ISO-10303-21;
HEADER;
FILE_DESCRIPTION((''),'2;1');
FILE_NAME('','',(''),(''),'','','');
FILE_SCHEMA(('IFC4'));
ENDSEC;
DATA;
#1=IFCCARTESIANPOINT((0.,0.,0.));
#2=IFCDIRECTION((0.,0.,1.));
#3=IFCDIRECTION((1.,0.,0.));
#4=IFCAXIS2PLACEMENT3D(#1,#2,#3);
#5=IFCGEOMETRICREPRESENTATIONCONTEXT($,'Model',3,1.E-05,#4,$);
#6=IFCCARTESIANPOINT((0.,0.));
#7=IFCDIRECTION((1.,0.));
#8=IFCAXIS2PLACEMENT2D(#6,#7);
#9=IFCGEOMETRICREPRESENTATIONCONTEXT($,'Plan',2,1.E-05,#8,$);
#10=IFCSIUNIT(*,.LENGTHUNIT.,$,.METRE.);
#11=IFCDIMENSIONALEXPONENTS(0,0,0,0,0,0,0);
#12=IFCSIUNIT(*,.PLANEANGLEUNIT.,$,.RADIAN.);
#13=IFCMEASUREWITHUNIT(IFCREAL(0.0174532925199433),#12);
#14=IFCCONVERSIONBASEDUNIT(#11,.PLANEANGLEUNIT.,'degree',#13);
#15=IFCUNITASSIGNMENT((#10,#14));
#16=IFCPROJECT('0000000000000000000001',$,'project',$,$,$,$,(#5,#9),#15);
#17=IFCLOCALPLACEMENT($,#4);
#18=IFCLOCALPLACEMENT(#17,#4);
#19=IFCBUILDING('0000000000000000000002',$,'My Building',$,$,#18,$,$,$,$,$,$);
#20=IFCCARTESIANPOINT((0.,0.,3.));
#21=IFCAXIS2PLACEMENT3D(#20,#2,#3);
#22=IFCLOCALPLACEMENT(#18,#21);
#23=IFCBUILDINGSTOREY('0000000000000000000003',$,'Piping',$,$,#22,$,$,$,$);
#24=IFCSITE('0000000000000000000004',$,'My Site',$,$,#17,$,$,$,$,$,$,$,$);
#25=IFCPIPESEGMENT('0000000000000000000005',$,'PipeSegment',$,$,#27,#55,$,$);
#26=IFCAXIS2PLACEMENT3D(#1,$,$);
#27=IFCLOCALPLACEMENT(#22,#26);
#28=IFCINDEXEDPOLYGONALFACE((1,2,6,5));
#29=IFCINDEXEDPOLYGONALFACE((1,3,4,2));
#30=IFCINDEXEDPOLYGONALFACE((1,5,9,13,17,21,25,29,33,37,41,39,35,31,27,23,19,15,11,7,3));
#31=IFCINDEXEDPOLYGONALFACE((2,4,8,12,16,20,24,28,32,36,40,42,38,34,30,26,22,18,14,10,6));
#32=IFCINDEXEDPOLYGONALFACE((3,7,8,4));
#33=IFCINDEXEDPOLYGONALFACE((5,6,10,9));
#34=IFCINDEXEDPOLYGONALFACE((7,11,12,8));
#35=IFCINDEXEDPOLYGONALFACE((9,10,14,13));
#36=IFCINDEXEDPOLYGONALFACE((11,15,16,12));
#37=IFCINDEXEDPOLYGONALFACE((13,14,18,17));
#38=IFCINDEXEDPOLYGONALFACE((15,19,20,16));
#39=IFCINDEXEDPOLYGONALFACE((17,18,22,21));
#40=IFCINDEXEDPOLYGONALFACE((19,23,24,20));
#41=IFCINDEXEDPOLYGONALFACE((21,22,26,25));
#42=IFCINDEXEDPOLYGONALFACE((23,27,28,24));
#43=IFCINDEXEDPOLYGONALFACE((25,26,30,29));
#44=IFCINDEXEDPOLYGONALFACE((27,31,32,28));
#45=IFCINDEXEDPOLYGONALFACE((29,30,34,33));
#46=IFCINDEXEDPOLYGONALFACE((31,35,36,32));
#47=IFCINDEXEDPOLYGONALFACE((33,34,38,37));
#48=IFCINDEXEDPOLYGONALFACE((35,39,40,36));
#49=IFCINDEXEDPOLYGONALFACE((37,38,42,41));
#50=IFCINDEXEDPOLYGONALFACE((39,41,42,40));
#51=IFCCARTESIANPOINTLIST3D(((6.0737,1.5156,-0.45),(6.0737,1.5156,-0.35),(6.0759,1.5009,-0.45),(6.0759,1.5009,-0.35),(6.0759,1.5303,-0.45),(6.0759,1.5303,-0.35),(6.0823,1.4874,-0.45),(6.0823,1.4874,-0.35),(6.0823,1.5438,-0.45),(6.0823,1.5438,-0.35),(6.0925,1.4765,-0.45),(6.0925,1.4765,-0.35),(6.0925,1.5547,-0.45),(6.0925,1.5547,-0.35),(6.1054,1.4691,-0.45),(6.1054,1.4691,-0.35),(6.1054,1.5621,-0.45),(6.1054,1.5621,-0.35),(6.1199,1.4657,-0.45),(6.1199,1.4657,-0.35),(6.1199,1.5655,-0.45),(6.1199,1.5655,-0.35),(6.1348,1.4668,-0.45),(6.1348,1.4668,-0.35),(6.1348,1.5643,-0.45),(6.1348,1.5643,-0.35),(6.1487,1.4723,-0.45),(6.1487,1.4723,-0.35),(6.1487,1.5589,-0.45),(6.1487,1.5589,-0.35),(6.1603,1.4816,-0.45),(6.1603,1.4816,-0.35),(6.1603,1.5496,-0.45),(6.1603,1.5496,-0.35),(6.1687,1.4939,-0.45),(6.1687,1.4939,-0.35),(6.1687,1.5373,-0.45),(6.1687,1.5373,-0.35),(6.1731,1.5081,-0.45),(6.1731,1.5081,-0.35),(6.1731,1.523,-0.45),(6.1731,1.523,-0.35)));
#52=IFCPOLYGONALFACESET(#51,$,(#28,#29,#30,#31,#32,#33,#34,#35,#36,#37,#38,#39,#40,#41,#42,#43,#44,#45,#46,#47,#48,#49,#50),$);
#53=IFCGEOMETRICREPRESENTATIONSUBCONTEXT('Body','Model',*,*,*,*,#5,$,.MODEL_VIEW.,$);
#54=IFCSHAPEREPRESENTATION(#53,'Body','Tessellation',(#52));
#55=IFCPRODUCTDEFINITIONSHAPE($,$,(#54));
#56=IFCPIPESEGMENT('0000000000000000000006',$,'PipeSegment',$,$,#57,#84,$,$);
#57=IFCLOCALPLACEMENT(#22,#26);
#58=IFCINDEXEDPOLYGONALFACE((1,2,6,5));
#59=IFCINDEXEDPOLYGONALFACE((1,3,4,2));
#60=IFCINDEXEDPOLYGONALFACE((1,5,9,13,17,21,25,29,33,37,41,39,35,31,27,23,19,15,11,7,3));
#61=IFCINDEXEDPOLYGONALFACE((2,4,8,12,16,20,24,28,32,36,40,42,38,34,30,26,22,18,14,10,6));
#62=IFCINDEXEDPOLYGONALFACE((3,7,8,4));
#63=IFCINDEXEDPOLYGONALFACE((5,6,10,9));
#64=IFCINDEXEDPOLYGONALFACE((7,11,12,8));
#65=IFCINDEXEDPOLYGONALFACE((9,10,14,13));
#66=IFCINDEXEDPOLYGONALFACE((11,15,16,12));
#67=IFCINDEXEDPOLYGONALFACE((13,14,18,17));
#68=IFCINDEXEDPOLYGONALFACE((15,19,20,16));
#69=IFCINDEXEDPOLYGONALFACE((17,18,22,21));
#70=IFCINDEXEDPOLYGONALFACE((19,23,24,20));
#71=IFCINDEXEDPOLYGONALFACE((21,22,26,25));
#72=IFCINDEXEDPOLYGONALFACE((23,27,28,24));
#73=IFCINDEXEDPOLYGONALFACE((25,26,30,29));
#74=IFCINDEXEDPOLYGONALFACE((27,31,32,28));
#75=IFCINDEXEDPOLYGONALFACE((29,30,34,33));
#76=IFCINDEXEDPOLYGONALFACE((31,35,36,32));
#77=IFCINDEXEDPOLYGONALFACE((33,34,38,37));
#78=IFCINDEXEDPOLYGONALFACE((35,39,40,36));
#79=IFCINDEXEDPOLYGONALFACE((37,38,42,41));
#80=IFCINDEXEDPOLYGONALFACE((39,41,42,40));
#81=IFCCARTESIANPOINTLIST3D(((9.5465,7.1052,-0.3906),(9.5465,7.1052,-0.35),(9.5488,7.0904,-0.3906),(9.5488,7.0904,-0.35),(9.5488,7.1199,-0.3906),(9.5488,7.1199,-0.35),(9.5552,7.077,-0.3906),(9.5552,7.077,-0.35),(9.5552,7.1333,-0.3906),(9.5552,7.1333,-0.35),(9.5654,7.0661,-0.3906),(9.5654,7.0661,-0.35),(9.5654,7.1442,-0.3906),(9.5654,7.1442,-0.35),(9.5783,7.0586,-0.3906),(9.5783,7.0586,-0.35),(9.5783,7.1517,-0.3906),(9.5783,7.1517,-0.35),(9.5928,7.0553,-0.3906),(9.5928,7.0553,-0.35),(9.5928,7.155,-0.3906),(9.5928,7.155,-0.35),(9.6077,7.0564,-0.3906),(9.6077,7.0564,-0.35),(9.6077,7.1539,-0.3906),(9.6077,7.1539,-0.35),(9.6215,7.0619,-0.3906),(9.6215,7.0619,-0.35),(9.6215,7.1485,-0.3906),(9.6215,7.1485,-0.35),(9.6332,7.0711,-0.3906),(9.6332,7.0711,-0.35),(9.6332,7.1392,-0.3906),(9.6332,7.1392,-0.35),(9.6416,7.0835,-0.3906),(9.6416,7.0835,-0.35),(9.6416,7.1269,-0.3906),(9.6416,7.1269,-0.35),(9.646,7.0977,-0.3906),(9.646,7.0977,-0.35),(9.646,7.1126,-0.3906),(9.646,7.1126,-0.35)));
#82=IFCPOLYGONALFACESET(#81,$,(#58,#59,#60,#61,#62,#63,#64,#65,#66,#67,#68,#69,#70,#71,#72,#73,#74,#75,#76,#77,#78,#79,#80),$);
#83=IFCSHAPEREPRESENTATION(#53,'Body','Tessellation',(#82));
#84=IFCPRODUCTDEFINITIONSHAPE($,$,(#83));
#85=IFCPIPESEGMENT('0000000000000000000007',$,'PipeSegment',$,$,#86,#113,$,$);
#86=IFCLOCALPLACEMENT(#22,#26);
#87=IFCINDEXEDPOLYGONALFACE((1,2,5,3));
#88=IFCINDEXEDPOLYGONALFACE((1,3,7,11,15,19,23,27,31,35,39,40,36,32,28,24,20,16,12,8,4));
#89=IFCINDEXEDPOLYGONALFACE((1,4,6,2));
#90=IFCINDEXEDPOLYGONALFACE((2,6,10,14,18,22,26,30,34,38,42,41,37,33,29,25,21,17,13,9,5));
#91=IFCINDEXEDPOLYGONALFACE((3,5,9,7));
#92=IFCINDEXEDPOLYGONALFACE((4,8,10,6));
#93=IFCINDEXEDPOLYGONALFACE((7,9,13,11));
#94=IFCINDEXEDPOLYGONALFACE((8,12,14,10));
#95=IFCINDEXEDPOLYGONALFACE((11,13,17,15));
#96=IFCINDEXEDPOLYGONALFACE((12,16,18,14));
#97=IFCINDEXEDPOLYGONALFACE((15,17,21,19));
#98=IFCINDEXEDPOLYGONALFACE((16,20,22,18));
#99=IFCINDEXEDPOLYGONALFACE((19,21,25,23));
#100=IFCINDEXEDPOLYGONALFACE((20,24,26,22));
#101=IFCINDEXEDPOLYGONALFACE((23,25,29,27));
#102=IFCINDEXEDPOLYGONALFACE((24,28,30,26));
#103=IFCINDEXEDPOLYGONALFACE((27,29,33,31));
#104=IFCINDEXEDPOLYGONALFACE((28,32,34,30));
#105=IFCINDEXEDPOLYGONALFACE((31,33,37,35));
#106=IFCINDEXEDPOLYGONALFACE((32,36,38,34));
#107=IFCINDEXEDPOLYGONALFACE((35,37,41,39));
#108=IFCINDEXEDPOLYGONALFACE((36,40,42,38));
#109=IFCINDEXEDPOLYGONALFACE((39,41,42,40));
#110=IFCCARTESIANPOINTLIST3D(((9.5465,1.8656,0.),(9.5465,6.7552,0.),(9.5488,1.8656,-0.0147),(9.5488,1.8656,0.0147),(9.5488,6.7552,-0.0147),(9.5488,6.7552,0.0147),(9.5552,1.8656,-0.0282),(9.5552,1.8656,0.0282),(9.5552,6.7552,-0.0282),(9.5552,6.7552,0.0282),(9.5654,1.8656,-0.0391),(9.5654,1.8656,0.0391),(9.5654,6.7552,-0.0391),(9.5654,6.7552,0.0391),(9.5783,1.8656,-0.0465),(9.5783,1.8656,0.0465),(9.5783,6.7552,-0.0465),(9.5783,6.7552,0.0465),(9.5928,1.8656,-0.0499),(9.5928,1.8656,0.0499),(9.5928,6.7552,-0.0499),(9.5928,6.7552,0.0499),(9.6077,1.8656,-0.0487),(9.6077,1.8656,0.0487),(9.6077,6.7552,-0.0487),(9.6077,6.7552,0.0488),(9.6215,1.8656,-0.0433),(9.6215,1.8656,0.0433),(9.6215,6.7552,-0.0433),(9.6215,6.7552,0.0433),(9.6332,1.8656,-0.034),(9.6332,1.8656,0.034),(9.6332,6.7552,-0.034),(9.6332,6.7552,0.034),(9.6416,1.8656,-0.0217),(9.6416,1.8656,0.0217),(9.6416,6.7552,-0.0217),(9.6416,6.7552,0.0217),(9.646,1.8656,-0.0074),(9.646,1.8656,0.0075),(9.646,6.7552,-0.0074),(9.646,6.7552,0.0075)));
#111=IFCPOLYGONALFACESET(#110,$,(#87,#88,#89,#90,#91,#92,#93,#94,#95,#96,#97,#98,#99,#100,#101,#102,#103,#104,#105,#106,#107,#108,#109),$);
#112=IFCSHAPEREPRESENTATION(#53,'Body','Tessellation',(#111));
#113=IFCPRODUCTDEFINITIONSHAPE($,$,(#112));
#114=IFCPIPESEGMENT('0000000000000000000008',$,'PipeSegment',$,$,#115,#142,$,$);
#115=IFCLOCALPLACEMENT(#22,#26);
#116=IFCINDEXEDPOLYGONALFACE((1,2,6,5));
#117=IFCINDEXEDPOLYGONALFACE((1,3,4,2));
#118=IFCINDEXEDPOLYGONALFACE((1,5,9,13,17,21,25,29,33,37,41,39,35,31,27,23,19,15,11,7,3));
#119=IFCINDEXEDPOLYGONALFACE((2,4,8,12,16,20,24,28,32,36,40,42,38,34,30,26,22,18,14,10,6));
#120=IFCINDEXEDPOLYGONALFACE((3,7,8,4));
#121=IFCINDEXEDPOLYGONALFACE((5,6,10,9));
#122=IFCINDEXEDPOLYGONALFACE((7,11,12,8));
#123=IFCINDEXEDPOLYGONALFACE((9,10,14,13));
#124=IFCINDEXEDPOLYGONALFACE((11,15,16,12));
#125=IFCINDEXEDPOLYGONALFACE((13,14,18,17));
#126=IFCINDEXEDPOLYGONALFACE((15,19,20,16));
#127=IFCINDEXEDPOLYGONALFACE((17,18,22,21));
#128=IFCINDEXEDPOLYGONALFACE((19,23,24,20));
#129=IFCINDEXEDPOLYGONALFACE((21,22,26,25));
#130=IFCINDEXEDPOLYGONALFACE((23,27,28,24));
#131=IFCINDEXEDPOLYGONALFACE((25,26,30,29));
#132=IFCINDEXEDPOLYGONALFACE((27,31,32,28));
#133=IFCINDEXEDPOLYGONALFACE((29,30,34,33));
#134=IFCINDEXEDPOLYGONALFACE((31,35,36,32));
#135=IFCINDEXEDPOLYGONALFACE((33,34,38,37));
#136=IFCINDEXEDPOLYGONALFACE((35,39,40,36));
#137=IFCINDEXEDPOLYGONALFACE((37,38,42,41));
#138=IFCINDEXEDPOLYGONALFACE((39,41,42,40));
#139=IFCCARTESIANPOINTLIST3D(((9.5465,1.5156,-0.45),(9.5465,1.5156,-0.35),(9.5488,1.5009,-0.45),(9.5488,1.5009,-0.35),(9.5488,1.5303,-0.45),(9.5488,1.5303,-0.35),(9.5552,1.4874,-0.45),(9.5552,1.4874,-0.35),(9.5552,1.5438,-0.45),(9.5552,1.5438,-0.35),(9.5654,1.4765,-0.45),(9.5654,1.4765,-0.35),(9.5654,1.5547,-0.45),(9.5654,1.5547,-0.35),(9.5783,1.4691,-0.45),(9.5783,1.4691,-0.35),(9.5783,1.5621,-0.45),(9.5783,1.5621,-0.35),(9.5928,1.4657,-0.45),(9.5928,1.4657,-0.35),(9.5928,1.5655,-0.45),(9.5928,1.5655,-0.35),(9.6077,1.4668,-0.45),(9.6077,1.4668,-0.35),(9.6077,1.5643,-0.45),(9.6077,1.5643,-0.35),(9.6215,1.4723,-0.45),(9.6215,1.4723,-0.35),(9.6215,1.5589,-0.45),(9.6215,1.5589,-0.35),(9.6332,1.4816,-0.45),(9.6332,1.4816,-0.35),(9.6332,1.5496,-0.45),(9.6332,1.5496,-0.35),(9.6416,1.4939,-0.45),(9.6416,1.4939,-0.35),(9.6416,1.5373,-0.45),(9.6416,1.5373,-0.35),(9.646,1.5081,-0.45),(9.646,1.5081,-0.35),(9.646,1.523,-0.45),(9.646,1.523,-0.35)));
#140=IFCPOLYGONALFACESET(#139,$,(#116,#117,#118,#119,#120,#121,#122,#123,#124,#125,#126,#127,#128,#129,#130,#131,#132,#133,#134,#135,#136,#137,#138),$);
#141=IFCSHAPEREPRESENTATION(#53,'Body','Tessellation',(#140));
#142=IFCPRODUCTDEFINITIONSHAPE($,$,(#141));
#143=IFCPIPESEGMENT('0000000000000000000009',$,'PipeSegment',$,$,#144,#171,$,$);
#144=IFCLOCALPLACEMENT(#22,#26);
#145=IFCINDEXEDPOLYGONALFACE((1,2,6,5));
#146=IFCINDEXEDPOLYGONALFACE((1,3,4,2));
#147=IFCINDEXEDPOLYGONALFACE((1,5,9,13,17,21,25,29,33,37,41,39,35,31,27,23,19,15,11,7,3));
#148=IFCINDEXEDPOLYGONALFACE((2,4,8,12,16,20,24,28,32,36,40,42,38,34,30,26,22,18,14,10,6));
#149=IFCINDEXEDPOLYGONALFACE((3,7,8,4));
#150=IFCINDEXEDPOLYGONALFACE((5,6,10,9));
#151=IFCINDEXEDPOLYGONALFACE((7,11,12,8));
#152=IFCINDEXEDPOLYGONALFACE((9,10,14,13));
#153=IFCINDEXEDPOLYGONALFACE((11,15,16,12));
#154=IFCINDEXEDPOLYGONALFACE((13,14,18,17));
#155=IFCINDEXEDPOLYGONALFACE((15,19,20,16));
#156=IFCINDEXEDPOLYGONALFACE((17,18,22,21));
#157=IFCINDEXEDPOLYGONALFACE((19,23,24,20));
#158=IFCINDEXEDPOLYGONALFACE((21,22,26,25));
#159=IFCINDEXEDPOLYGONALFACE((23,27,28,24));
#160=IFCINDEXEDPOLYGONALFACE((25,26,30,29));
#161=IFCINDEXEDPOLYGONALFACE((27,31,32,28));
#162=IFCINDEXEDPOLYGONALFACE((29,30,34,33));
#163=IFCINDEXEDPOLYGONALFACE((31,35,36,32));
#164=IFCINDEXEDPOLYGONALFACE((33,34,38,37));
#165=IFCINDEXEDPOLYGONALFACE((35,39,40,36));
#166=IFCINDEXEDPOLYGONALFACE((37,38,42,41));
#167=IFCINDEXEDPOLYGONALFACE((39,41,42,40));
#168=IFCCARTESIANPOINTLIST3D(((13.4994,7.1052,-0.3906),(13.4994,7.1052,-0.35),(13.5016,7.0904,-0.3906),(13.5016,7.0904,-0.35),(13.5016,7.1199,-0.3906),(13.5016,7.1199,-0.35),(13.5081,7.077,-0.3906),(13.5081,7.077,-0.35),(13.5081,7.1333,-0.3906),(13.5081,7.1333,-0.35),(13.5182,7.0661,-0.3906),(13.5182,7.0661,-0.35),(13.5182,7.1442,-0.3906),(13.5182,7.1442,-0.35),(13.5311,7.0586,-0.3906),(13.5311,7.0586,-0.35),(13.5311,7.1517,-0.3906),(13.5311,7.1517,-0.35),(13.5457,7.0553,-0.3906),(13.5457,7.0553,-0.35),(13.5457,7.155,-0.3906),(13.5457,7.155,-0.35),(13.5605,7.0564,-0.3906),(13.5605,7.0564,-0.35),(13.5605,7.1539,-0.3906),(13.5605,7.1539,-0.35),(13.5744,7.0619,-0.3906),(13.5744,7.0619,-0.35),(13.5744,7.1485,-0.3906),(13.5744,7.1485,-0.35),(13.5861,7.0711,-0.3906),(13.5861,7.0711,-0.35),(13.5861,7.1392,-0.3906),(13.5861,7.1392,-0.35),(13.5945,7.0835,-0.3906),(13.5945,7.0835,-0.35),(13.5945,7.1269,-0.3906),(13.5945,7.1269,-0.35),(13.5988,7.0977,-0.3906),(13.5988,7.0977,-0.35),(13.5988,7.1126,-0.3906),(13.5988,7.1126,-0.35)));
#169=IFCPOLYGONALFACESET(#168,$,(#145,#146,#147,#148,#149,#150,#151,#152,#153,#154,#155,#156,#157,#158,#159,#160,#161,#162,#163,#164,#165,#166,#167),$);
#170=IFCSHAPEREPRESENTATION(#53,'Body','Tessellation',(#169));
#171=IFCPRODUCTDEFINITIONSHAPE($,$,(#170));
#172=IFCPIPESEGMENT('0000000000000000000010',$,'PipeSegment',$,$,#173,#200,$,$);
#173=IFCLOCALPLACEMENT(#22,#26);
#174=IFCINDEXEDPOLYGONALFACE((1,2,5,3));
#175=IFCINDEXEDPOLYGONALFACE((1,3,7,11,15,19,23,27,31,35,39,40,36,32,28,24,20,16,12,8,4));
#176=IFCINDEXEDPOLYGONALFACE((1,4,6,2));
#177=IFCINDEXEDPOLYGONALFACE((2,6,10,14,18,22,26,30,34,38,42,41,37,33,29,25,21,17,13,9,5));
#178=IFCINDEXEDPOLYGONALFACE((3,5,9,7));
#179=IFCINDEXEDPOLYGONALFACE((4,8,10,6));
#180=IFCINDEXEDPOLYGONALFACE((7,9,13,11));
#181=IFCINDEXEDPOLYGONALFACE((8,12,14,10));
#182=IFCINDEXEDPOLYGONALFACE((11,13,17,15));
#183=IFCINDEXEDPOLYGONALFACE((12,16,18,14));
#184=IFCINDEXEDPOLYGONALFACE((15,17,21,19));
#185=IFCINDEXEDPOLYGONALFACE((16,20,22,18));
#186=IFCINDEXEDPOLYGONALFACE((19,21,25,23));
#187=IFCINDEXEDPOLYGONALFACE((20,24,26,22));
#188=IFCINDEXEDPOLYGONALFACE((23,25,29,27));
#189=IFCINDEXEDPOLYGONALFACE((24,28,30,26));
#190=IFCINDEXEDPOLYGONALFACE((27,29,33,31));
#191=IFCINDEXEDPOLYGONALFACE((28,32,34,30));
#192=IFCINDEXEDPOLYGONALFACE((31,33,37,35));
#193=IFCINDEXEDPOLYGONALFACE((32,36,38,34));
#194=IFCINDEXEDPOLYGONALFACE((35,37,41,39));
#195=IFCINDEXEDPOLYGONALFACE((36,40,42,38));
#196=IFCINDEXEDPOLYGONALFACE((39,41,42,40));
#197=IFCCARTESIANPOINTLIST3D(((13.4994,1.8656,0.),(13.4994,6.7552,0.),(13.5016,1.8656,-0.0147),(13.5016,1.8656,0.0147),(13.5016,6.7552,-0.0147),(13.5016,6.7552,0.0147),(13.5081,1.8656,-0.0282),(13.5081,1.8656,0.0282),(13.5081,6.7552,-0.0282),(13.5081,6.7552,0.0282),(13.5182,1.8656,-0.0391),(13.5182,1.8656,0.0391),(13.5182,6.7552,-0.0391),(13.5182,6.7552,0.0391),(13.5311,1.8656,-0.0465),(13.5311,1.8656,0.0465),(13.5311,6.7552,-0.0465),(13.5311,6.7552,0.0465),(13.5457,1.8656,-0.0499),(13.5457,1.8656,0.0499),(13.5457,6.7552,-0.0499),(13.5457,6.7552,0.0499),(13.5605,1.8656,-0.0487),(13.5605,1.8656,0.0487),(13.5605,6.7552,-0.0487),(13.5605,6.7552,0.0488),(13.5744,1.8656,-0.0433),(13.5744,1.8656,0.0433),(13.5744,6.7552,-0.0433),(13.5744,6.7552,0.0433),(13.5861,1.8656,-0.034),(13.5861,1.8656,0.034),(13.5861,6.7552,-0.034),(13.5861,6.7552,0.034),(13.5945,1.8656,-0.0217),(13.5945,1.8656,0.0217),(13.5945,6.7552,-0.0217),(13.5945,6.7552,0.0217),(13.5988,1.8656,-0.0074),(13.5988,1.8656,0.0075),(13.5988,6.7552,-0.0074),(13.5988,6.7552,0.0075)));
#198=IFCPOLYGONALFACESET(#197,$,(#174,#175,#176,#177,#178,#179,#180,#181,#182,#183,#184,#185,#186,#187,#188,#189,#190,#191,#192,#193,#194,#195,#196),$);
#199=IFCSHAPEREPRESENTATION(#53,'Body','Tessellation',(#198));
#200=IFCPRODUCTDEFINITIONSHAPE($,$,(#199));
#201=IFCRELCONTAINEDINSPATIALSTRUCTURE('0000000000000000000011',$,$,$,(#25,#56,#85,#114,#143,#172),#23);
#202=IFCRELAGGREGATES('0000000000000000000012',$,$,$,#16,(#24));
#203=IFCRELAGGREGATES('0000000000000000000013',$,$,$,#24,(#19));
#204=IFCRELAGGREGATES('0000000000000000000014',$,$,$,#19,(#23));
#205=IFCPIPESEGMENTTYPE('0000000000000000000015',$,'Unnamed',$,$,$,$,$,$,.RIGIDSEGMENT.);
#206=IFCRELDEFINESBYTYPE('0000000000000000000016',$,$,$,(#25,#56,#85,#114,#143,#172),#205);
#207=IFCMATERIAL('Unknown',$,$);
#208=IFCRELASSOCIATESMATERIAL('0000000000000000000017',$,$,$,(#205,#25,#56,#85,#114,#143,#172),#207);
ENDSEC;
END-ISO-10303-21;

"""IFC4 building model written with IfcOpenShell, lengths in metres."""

from ifc_helpers import new_model, entity, si_unit, converted_unit, frame, origin_with_axes, origin_2d_with_axis, place, context, subcontext, project, spatial, circle, extrude, material, material_profile, profile_set, profile_usage, type_object, element, save


model = new_model("IFC4")

# Units and contexts
model_context = context("Model", 3, precision=1e-05, world=origin_with_axes())
plan_context = context("Plan", 2, precision=1e-05, world=origin_2d_with_axis())
body_context = subcontext(model_context, "Body", "Model", "MODEL_VIEW")
ifc_project = project(units=[si_unit("LENGTHUNIT", "METRE"), converted_unit("PLANEANGLEUNIT", "degree", entity("IfcReal", 0.0174532925199433), si_unit("PLANEANGLEUNIT", "RADIAN"), dimensions=[0, 0, 0, 0, 0, 0, 0])], contexts=[model_context, plan_context])

# Site, building, storey
site_placement = place(None, origin_with_axes())
site = spatial("IfcSite", under=ifc_project, at=site_placement, Name="My Site")
building_placement = place(site_placement, origin_with_axes())
building = spatial("IfcBuilding", under=site, at=building_placement, Name="My Building")
storey_placement = place(building_placement, frame((0.0, 0.0, 3.0), z_axis=(0.0, 0.0, 1.0), x_axis=(1.0, 0.0, 0.0)))
storey = spatial("IfcBuildingStorey", under=building, at=storey_placement, Name="Piping")

# Pipe segments
ifc_material = material(Name="Unknown")
ifc_material_profile = material_profile(ifc_material, circle(Radius=0.05))
ifc_profile_set = profile_set([ifc_material_profile])
pipe_segment_type = type_object("IfcPipeSegmentType", Name="Unnamed", PredefinedType="RIGIDSEGMENT", material=ifc_profile_set)
ifc_profile_usage_1 = profile_usage(ifc_profile_set, cardinal=5)
pipe_segment_1_placement = place(storey_placement, frame((6.1237, 1.5156, -0.35), z_axis=(0.0, 0.0, -1.0), x_axis=(-1.0, 0.0, 0.0)))
element("IfcPipeSegment", 1, at=pipe_segment_1_placement, inside=storey, type_object=pipe_segment_type, material=ifc_profile_usage_1, Name="PipeSegment", context=body_context, shape_type="SweptSolid", body=[
    extrude(circle(Radius=0.05), origin_with_axes(), (0.0, 0.0, 1.0), 0.1),
])
ifc_profile_usage_2 = profile_usage(ifc_profile_set, cardinal=5)
pipe_segment_2_placement = place(storey_placement, frame((9.5965, 7.1052, -0.35), z_axis=(0.0, 0.0, -1.0), x_axis=(-1.0, 0.0, 0.0)))
element("IfcPipeSegment", 2, at=pipe_segment_2_placement, inside=storey, type_object=pipe_segment_type, material=ifc_profile_usage_2, Name="PipeSegment", context=body_context, shape_type="SweptSolid", body=[
    extrude(circle(Radius=0.05), origin_with_axes(), (0.0, 0.0, 1.0), 0.0406),
])
ifc_profile_usage_3 = profile_usage(ifc_profile_set, cardinal=5)
pipe_segment_3_placement = place(storey_placement, frame((9.5965, 1.8656, 0.0), z_axis=(0.0, 1.0, 0.0), x_axis=(-1.0, 0.0, 0.0)))
element("IfcPipeSegment", 3, at=pipe_segment_3_placement, inside=storey, type_object=pipe_segment_type, material=ifc_profile_usage_3, Name="PipeSegment", context=body_context, shape_type="SweptSolid", body=[
    extrude(circle(Radius=0.05), origin_with_axes(), (0.0, 0.0, 1.0), 4.8896),
])
ifc_profile_usage_4 = profile_usage(ifc_profile_set, cardinal=5)
pipe_segment_4_placement = place(storey_placement, frame((9.5965, 1.5156, -0.35), z_axis=(0.0, 0.0, -1.0), x_axis=(-1.0, 0.0, 0.0)))
element("IfcPipeSegment", 4, at=pipe_segment_4_placement, inside=storey, type_object=pipe_segment_type, material=ifc_profile_usage_4, Name="PipeSegment", context=body_context, shape_type="SweptSolid", body=[
    extrude(circle(Radius=0.05), origin_with_axes(), (0.0, 0.0, 1.0), 0.1),
])
ifc_profile_usage_5 = profile_usage(ifc_profile_set, cardinal=5)
pipe_segment_5_placement = place(storey_placement, frame((13.5494, 7.1052, -0.35), z_axis=(0.0, 0.0, -1.0), x_axis=(-1.0, 0.0, 0.0)))
element("IfcPipeSegment", 5, at=pipe_segment_5_placement, inside=storey, type_object=pipe_segment_type, material=ifc_profile_usage_5, Name="PipeSegment", context=body_context, shape_type="SweptSolid", body=[
    extrude(circle(Radius=0.05), origin_with_axes(), (0.0, 0.0, 1.0), 0.0406),
])
ifc_profile_usage_6 = profile_usage(ifc_profile_set, cardinal=5)
pipe_segment_6_placement = place(storey_placement, frame((13.5494, 1.8656, 0.0), z_axis=(0.0, 1.0, 0.0), x_axis=(-1.0, 0.0, 0.0)))
element("IfcPipeSegment", 6, at=pipe_segment_6_placement, inside=storey, type_object=pipe_segment_type, material=ifc_profile_usage_6, Name="PipeSegment", context=body_context, shape_type="SweptSolid", body=[
    extrude(circle(Radius=0.05), origin_with_axes(), (0.0, 0.0, 1.0), 4.8896),
])

save(model, "model.ifc")
